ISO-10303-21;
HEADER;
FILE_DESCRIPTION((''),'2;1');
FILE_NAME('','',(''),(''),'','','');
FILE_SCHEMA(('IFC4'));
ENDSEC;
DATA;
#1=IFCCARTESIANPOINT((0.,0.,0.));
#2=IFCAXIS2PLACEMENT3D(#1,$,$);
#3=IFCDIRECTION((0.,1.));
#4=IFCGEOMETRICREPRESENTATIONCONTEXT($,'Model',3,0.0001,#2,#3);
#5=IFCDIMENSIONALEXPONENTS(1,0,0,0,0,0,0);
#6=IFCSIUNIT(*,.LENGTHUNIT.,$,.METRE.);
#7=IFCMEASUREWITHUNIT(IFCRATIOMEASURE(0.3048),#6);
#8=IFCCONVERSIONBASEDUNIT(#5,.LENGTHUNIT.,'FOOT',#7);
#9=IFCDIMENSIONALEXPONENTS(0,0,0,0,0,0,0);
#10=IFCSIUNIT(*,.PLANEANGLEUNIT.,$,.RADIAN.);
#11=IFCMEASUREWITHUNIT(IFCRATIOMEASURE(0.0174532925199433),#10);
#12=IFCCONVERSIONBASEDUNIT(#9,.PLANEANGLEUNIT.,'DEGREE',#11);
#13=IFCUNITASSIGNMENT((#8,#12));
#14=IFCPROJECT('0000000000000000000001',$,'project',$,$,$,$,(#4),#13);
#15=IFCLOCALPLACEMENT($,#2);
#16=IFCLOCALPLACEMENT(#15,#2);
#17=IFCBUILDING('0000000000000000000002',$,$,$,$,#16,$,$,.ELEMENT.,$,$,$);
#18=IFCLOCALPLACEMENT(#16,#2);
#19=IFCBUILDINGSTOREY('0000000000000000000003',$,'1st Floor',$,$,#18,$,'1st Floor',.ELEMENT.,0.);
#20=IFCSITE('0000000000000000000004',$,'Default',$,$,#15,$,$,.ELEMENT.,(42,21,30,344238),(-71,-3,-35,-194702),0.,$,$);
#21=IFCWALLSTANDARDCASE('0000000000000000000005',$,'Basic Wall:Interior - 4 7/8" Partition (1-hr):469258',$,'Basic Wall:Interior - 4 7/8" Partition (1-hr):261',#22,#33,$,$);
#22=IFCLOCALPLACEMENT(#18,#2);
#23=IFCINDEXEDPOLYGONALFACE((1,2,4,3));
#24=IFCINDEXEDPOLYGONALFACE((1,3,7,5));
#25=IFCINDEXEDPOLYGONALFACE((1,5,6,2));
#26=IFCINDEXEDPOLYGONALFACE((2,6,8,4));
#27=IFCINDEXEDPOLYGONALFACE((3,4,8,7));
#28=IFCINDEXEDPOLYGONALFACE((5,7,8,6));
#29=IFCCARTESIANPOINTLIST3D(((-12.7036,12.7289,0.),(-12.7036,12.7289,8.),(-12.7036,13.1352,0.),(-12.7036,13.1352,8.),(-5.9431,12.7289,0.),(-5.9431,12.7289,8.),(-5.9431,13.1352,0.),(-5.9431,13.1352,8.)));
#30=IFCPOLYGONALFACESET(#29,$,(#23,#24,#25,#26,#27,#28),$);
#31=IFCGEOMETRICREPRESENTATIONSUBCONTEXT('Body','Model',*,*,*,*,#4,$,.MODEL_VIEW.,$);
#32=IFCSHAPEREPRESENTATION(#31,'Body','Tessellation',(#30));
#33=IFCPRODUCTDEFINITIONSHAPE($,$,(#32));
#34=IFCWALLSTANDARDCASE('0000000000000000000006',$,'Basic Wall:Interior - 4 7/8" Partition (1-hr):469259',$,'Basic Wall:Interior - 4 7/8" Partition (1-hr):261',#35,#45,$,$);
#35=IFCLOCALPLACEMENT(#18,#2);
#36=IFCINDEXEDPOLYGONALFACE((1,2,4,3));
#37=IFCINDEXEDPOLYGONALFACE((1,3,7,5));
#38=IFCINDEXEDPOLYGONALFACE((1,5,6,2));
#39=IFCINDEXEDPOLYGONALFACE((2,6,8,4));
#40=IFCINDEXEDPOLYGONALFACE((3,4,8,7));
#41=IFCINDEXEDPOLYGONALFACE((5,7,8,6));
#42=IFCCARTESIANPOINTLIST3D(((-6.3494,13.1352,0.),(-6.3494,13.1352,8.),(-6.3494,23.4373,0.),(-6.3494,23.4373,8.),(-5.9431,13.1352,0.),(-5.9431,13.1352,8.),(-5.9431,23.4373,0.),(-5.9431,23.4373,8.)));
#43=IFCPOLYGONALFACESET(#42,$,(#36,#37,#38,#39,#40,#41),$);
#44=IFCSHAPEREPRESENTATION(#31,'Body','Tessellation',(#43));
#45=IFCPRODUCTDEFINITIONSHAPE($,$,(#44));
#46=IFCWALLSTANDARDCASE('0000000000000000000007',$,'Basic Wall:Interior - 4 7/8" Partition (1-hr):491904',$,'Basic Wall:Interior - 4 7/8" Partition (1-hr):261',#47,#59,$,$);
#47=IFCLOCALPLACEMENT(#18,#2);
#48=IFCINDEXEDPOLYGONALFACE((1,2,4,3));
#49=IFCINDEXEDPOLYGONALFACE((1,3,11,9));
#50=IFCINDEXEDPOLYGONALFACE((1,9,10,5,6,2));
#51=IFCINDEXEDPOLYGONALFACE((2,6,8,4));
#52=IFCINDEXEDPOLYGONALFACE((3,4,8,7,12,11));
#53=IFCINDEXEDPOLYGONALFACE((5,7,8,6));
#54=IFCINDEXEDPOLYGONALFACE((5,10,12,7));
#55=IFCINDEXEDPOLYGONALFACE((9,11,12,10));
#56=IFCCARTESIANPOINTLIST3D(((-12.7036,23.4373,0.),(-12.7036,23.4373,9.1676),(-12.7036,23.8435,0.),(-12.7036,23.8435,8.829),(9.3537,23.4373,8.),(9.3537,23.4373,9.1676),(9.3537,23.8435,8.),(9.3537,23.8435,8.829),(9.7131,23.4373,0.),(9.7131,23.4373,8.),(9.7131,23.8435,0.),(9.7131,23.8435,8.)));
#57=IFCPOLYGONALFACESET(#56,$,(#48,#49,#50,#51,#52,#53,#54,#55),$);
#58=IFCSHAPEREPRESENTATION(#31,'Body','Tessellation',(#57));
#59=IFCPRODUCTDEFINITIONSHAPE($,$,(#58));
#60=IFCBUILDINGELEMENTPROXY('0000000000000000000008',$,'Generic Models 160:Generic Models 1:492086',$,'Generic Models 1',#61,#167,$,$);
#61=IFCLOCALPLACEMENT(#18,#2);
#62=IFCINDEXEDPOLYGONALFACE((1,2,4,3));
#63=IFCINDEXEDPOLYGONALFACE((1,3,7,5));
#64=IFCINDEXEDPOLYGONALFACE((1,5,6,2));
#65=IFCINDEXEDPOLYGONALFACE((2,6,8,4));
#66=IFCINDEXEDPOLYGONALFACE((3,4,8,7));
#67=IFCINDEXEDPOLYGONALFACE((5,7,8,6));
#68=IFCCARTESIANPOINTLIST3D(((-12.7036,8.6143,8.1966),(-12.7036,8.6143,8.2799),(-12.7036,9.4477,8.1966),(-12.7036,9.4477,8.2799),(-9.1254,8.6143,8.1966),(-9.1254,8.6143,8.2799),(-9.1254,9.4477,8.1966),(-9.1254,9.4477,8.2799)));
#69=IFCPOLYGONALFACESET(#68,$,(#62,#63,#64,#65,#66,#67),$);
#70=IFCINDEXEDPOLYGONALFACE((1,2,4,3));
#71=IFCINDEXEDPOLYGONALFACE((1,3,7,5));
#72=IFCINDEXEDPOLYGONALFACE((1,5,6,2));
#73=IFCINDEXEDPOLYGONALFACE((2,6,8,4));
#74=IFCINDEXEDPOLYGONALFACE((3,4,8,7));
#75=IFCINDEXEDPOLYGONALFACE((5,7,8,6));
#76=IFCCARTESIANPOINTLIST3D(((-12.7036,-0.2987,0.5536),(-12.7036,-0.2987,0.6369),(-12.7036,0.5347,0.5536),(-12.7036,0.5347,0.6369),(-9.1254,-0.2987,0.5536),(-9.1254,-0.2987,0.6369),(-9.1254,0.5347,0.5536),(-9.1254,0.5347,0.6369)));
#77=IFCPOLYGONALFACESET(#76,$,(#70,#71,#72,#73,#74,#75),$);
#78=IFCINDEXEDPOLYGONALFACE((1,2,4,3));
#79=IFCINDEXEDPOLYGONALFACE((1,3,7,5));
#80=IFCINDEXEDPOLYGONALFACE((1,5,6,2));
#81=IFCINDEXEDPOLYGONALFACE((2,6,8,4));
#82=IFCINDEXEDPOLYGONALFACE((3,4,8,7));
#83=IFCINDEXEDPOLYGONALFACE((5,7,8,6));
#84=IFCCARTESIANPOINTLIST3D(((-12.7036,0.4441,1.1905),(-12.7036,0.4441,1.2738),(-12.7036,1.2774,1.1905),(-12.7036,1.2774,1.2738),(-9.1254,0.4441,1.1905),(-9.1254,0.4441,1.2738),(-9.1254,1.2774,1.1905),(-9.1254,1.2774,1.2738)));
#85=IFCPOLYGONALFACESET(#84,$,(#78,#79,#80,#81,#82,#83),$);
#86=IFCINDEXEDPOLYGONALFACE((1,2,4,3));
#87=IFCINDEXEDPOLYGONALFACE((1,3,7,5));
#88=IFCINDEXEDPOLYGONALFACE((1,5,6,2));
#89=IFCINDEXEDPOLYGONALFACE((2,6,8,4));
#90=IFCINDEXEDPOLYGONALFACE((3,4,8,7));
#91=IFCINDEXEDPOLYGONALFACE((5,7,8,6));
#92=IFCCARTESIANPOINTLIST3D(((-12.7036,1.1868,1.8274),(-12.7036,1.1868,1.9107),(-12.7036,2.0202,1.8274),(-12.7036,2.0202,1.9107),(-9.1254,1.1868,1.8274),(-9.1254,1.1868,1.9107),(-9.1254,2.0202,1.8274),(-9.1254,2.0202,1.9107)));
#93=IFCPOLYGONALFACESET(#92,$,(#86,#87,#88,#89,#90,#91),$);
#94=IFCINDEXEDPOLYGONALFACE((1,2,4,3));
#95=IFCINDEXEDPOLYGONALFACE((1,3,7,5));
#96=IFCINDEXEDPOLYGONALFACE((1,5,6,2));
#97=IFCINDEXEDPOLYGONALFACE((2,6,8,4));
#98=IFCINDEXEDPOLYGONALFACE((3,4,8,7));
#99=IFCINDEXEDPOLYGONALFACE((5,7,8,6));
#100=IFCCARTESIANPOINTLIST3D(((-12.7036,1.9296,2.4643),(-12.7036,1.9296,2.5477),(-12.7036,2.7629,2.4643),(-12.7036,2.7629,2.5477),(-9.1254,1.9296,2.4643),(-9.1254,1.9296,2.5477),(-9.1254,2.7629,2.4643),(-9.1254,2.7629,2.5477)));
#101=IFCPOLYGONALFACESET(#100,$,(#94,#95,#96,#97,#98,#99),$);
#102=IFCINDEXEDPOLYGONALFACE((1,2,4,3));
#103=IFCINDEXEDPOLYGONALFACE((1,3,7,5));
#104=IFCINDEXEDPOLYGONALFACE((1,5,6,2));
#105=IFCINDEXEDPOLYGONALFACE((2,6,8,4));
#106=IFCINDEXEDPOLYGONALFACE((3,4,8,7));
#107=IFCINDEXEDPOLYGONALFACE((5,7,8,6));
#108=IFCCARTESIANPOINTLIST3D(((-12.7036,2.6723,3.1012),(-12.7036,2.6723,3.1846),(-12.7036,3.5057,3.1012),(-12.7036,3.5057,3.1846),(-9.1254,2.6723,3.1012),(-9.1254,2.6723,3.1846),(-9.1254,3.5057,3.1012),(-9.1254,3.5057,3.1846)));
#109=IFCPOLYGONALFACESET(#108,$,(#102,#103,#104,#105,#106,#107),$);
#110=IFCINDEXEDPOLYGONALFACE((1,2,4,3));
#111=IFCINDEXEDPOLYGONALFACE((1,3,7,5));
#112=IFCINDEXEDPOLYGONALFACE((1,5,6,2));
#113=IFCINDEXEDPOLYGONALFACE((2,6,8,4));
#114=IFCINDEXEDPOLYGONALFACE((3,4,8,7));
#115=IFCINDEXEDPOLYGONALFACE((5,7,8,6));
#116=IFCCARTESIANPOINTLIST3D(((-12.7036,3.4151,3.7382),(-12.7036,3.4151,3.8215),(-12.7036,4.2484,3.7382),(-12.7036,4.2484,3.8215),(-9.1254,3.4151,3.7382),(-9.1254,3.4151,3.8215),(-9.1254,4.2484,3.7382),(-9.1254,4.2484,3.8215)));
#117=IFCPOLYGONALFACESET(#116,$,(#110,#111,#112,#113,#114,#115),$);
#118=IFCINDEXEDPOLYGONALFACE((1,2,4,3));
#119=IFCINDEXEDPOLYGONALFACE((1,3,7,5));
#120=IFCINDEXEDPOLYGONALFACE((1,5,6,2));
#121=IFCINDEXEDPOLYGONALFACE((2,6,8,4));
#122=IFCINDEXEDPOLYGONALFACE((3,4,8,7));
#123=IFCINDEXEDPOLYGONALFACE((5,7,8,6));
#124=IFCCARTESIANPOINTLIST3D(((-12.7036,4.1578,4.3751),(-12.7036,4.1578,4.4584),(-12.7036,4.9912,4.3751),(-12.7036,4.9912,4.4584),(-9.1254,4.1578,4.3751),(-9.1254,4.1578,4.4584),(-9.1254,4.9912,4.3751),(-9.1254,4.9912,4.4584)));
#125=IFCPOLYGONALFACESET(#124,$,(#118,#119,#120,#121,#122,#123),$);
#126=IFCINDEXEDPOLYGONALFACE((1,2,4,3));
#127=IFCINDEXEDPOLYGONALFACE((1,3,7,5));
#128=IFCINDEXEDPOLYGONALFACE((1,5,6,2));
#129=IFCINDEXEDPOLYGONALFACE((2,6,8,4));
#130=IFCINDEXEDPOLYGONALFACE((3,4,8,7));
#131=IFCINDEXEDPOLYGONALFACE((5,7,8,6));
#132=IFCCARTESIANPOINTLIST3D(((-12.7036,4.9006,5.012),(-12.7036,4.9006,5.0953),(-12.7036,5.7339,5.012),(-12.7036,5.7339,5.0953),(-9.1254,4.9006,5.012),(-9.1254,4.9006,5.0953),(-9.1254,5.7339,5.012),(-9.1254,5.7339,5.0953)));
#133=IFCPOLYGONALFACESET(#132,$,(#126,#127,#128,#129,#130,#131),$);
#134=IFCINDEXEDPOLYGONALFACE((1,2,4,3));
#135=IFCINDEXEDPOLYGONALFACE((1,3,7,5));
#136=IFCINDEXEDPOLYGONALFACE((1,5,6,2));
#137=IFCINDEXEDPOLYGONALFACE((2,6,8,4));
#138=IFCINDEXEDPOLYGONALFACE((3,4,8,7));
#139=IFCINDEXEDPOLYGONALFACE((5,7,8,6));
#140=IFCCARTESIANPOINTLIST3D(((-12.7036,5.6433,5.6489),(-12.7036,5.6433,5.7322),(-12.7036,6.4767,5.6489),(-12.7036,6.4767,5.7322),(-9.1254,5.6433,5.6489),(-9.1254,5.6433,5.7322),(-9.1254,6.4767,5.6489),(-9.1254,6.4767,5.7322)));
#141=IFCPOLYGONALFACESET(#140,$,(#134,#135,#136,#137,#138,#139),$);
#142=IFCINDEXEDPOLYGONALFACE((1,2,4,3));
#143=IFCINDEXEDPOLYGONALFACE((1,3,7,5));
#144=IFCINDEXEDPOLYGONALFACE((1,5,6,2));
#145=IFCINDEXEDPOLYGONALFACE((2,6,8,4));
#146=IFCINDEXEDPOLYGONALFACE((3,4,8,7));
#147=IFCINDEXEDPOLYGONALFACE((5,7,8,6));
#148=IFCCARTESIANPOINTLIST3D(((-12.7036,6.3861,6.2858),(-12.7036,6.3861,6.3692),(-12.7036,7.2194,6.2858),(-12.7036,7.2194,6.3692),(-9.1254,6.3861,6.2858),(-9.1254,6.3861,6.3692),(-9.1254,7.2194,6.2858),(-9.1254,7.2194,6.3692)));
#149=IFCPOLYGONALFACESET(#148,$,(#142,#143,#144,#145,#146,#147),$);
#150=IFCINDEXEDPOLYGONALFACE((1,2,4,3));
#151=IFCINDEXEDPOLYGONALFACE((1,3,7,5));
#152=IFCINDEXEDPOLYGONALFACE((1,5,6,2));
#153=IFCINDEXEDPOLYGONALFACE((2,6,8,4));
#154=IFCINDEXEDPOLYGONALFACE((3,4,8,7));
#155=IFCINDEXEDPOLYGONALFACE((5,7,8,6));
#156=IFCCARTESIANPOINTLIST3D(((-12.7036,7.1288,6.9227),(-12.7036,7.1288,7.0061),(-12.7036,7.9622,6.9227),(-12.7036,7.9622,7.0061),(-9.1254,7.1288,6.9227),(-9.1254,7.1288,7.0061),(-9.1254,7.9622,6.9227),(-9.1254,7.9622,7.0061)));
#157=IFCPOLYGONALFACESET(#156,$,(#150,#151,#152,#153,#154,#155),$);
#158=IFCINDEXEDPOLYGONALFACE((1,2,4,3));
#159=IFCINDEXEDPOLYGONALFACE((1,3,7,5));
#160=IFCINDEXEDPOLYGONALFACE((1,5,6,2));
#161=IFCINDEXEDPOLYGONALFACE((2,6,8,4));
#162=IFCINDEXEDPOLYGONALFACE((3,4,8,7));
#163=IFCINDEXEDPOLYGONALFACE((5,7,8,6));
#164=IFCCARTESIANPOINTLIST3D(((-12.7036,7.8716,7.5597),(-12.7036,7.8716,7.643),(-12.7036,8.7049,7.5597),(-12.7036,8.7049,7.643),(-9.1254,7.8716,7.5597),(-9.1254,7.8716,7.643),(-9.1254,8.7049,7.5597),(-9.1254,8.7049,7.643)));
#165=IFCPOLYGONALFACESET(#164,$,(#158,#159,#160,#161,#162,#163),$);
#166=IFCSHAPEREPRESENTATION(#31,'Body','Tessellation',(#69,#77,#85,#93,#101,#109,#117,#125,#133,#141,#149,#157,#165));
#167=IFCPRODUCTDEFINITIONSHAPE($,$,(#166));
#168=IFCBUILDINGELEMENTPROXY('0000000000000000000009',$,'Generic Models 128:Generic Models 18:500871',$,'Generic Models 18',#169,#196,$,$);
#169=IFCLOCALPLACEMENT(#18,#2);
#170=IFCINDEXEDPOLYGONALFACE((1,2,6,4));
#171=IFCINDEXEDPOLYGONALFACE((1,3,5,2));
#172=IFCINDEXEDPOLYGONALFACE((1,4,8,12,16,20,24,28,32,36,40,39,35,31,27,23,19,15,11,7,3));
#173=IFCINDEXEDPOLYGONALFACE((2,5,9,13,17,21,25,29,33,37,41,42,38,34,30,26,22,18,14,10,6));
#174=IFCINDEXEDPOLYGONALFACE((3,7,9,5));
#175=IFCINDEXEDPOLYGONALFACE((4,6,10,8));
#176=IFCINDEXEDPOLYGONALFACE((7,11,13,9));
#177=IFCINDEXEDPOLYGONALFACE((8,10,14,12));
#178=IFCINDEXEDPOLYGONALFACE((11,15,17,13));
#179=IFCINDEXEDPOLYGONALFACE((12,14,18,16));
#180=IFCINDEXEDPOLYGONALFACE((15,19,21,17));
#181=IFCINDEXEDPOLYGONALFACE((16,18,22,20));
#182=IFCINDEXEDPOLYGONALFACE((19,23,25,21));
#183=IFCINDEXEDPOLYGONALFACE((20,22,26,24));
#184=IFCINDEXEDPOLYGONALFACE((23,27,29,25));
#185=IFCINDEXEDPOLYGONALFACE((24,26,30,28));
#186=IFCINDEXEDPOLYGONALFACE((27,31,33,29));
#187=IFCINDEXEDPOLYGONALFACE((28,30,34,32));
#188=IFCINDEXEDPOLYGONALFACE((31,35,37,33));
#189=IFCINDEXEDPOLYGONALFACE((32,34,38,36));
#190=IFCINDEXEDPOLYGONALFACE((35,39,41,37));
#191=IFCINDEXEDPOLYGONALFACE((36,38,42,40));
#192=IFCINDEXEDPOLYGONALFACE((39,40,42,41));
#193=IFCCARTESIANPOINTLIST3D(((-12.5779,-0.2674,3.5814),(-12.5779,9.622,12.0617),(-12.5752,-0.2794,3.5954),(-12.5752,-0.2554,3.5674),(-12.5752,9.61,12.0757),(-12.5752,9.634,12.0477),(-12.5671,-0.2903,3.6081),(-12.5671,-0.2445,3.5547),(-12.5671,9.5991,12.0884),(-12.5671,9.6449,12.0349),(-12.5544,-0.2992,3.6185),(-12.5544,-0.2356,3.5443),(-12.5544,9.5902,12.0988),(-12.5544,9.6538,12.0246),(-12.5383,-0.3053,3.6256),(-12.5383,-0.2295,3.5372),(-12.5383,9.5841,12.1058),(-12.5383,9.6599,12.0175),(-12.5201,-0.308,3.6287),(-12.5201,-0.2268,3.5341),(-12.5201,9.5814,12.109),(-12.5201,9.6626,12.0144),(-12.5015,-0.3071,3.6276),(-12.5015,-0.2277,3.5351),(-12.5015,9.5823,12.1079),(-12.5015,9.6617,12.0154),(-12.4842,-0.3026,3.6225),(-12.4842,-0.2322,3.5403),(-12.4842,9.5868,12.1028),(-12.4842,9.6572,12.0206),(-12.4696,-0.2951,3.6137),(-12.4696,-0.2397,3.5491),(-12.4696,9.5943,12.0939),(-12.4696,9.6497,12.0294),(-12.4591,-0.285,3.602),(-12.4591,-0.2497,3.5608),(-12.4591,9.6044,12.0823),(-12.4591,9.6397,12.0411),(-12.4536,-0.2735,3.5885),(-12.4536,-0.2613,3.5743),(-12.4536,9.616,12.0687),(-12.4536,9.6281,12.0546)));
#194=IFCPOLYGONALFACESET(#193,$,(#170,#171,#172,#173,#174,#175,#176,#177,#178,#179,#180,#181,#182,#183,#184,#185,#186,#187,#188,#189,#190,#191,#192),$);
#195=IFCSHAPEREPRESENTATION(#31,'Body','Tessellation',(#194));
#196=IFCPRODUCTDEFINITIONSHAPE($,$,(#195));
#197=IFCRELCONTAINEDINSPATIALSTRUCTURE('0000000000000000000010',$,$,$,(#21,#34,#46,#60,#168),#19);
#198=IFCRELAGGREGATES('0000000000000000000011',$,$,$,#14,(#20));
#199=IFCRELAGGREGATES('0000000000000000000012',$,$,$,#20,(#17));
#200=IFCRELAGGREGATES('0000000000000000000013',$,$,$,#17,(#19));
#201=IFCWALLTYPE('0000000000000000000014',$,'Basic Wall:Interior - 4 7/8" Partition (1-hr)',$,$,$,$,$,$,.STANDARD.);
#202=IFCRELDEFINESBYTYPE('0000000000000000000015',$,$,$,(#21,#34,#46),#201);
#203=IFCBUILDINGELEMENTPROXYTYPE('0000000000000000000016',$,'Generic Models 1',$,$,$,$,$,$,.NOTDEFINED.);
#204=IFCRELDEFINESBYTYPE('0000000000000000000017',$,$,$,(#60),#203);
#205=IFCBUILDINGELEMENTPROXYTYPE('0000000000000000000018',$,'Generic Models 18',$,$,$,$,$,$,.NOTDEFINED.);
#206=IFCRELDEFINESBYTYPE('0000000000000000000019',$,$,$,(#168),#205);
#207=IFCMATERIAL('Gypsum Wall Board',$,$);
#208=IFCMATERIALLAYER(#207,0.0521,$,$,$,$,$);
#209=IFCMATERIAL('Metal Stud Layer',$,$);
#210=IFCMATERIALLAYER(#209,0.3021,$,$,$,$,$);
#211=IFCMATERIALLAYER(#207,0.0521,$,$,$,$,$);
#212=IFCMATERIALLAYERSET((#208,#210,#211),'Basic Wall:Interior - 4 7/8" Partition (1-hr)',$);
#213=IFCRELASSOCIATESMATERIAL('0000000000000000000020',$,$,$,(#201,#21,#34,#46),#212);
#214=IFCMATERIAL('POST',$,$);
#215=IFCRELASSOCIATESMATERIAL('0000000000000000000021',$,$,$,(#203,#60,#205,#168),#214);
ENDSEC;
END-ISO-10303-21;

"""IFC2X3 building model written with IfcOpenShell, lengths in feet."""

from ifc_helpers import new_model, entity, si_unit, converted_unit, direction, frame, frame_2d, origin, place, context, subcontext, project, spatial, polyline, rectangle, circle, extrude, clip, bounded_halfspace, source, transform, mapped, material, layer, layer_set, layer_usage, type_object, type_shapes, element, save


model = new_model("IFC2X3")

# Units and contexts
model_context = context("Model", 3, precision=0.0001, world=origin(), true_north=direction((0.0, 1.0)))
body_context = subcontext(model_context, "Body", "Model", "MODEL_VIEW")
ifc_project = project(units=[converted_unit("LENGTHUNIT", "FOOT", entity("IfcRatioMeasure", 0.3048), si_unit("LENGTHUNIT", "METRE"), dimensions=[1, 0, 0, 0, 0, 0, 0]), converted_unit("PLANEANGLEUNIT", "DEGREE", entity("IfcRatioMeasure", 0.0174532925199433), si_unit("PLANEANGLEUNIT", "RADIAN"), dimensions=[0, 0, 0, 0, 0, 0, 0])], contexts=[model_context])

# Site, building, storey
site_placement = place(None, origin())
site = spatial("IfcSite", under=ifc_project, at=site_placement, Name="Default", CompositionType="ELEMENT", RefLatitude=(42, 21, 30, 344238), RefLongitude=(-71, -3, -35, -194702), RefElevation=0.0)
building_placement = place(site_placement, origin())
building = spatial("IfcBuilding", under=site, at=building_placement, CompositionType="ELEMENT")
storey_placement = place(building_placement, origin())
storey = spatial("IfcBuildingStorey", under=building, at=storey_placement, Name="1st Floor", LongName="1st Floor", CompositionType="ELEMENT", Elevation=0.0)

# Walls
ifc_material_1 = material(Name="Gypsum Wall Board")
ifc_layer_1 = layer(ifc_material_1, 0.0521)
ifc_material_2 = material(Name="Metal Stud Layer")
ifc_layer_2 = layer(ifc_material_2, 0.3021)
ifc_layer_3 = layer(ifc_material_1, 0.0521)
ifc_layer_set = layer_set([ifc_layer_1, ifc_layer_2, ifc_layer_3], Name="Basic Wall:Interior - 4 7/8\" Partition (1-hr)")
ifc_layer_usage_1 = layer_usage(ifc_layer_set, "AXIS2", "NEGATIVE", 0.2031)
wall_type = type_object("IfcWallType", Name="Basic Wall:Interior - 4 7/8\" Partition (1-hr)", PredefinedType="STANDARD", material=ifc_layer_set)
wall_1_placement = place(storey_placement, frame((-12.7036, 12.9321, 0.0)))
element("IfcWallStandardCase", 1, at=wall_1_placement, inside=storey, type_object=wall_type, material=ifc_layer_usage_1, Name="Basic Wall:Interior - 4 7/8\" Partition (1-hr):469258", ObjectType="Basic Wall:Interior - 4 7/8\" Partition (1-hr):261", context=body_context, shape_type="SweptSolid", body=[
    extrude(rectangle(XDim=6.7604, YDim=0.4062, at=frame_2d((3.3802, 0.0), x_axis=(-1.0, 0.0))), origin(), (0.0, 0.0, 1.0), 8.0),
])
ifc_layer_usage_2 = layer_usage(ifc_layer_set, "AXIS2", "NEGATIVE", 0.2031)
wall_2_placement = place(storey_placement, frame((-6.1463, 13.1352, 0.0), z_axis=(0.0, 0.0, 1.0), x_axis=(0.0, 1.0, 0.0)))
element("IfcWallStandardCase", 2, at=wall_2_placement, inside=storey, type_object=wall_type, material=ifc_layer_usage_2, Name="Basic Wall:Interior - 4 7/8\" Partition (1-hr):469259", ObjectType="Basic Wall:Interior - 4 7/8\" Partition (1-hr):261", context=body_context, shape_type="SweptSolid", body=[
    extrude(rectangle(XDim=10.3021, YDim=0.4062, at=frame_2d((5.151, 0.0), x_axis=(-1.0, 0.0))), origin(), (0.0, 0.0, 1.0), 8.0),
])
ifc_layer_usage_3 = layer_usage(ifc_layer_set, "AXIS2", "NEGATIVE", 0.2031)
wall_3_placement = place(storey_placement, frame((-12.7036, 23.6404, 0.0)))
element("IfcWallStandardCase", 3, at=wall_3_placement, inside=storey, type_object=wall_type, material=ifc_layer_usage_3, Name="Basic Wall:Interior - 4 7/8\" Partition (1-hr):491904", ObjectType="Basic Wall:Interior - 4 7/8\" Partition (1-hr):261", context=body_context, shape_type="Clipping", body=[
    clip(clip(extrude(rectangle(XDim=22.4167, YDim=0.4062, at=frame_2d((11.2083, 0.0), x_axis=(-1.0, 0.0))), origin(), (0.0, 0.0, 1.0), 9.1676), bounded_halfspace(frame((0.0, -0.2031, 9.1676), z_axis=(0.0, 0.640184, 0.768221), x_axis=(-1.0, 0.0, 0.0)), False, frame((0.0, -0.2031, 9.1676)), polyline([(0.0, 0.0), (22.0573, 0.0), (22.0573, 0.4062), (0.0, 0.4062), (0.0, 0.0)]))), bounded_halfspace(frame((22.0573, -0.2031, 8.0), z_axis=(0.0, 0.0, 1.0), x_axis=(0.0, 1.0, 0.0)), False, frame((22.0573, -0.2031, 8.0)), polyline([(0.0, 0.0), (0.3594, 0.0), (0.3594, 0.4062), (0.0, 0.4062), (0.0, 0.0)]))),
])

# Building element proxies
ifc_material_3 = material(Name="POST")
building_element_proxy_type_1 = type_object("IfcBuildingElementProxyType", Name="Generic Models 1", PredefinedType="NOTDEFINED", material=ifc_material_3)
shared_shape_1 = source(origin(), body_context, "Body", "SweptSolid", [
    extrude(rectangle(XDim=3.5782, YDim=0.8333, at=frame_2d((0.0, 0.0), x_axis=(1.0, 0.0))), frame((-10.9145, 9.031, 8.1966), z_axis=(0.0, 0.0, 1.0), x_axis=(-1.0, 0.0, 0.0)), (0.0, 0.0, 1.0), 0.0833),
    extrude(rectangle(XDim=3.5782, YDim=0.8333, at=frame_2d((0.0, 0.0), x_axis=(1.0, 0.0))), frame((-10.9145, 0.118, 0.5536), z_axis=(0.0, 0.0, 1.0), x_axis=(-1.0, 0.0, 0.0)), (0.0, 0.0, 1.0), 0.0833),
    extrude(rectangle(XDim=3.5782, YDim=0.8333, at=frame_2d((0.0, 0.0), x_axis=(1.0, 0.0))), frame((-10.9145, 0.8608, 1.1905), z_axis=(0.0, 0.0, 1.0), x_axis=(-1.0, 0.0, 0.0)), (0.0, 0.0, 1.0), 0.0833),
    extrude(rectangle(XDim=3.5782, YDim=0.8333, at=frame_2d((0.0, 0.0), x_axis=(1.0, 0.0))), frame((-10.9145, 1.6035, 1.8274), z_axis=(0.0, 0.0, 1.0), x_axis=(-1.0, 0.0, 0.0)), (0.0, 0.0, 1.0), 0.0833),
    extrude(rectangle(XDim=3.5782, YDim=0.8333, at=frame_2d((0.0, 0.0), x_axis=(1.0, 0.0))), frame((-10.9145, 2.3463, 2.4643), z_axis=(0.0, 0.0, 1.0), x_axis=(-1.0, 0.0, 0.0)), (0.0, 0.0, 1.0), 0.0833),
    extrude(rectangle(XDim=3.5782, YDim=0.8333, at=frame_2d((0.0, 0.0), x_axis=(1.0, 0.0))), frame((-10.9145, 3.089, 3.1012), z_axis=(0.0, 0.0, 1.0), x_axis=(-1.0, 0.0, 0.0)), (0.0, 0.0, 1.0), 0.0833),
    extrude(rectangle(XDim=3.5782, YDim=0.8333, at=frame_2d((0.0, 0.0), x_axis=(1.0, 0.0))), frame((-10.9145, 3.8318, 3.7382), z_axis=(0.0, 0.0, 1.0), x_axis=(-1.0, 0.0, 0.0)), (0.0, 0.0, 1.0), 0.0833),
    extrude(rectangle(XDim=3.5782, YDim=0.8333, at=frame_2d((0.0, 0.0), x_axis=(1.0, 0.0))), frame((-10.9145, 4.5745, 4.3751), z_axis=(0.0, 0.0, 1.0), x_axis=(-1.0, 0.0, 0.0)), (0.0, 0.0, 1.0), 0.0833),
    extrude(rectangle(XDim=3.5782, YDim=0.8333, at=frame_2d((0.0, 0.0), x_axis=(1.0, 0.0))), frame((-10.9145, 5.3173, 5.012), z_axis=(0.0, 0.0, 1.0), x_axis=(-1.0, 0.0, 0.0)), (0.0, 0.0, 1.0), 0.0833),
    extrude(rectangle(XDim=3.5782, YDim=0.8333, at=frame_2d((0.0, 0.0), x_axis=(1.0, 0.0))), frame((-10.9145, 6.06, 5.6489), z_axis=(0.0, 0.0, 1.0), x_axis=(-1.0, 0.0, 0.0)), (0.0, 0.0, 1.0), 0.0833),
    extrude(rectangle(XDim=3.5782, YDim=0.8333, at=frame_2d((0.0, 0.0), x_axis=(1.0, 0.0))), frame((-10.9145, 6.8028, 6.2858), z_axis=(0.0, 0.0, 1.0), x_axis=(-1.0, 0.0, 0.0)), (0.0, 0.0, 1.0), 0.0833),
    extrude(rectangle(XDim=3.5782, YDim=0.8333, at=frame_2d((0.0, 0.0), x_axis=(1.0, 0.0))), frame((-10.9145, 7.5455, 6.9227), z_axis=(0.0, 0.0, 1.0), x_axis=(-1.0, 0.0, 0.0)), (0.0, 0.0, 1.0), 0.0833),
    extrude(rectangle(XDim=3.5782, YDim=0.8333, at=frame_2d((0.0, 0.0), x_axis=(1.0, 0.0))), frame((-10.9145, 8.2883, 7.5597), z_axis=(0.0, 0.0, 1.0), x_axis=(-1.0, 0.0, 0.0)), (0.0, 0.0, 1.0), 0.0833),
])
type_shapes(building_element_proxy_type_1, [shared_shape_1])
proxy_1_placement = place(storey_placement, origin())
element("IfcBuildingElementProxy", 4, at=proxy_1_placement, inside=storey, type_object=building_element_proxy_type_1, material=ifc_material_3, Name="Generic Models 160:Generic Models 1:492086", ObjectType="Generic Models 1", context=body_context, shape_type="MappedRepresentation", body=[
    mapped(shared_shape_1, transform((0.0, 0.0, 0.0), scale=1.0)),
])
building_element_proxy_type_2 = type_object("IfcBuildingElementProxyType", Name="Generic Models 18", PredefinedType="NOTDEFINED", material=ifc_material_3)
shared_shape_2 = source(origin(), body_context, "Body", "SweptSolid", [
    extrude(circle(Radius=0.0625, at=frame_2d((0.0, 0.0), x_axis=(1.0, 0.0))), frame((-12.5154, -0.2674, 3.5814), z_axis=(0.0, 0.759118, 0.650953), x_axis=(-1.0, 0.0, 0.0)), (0.0, 0.0, 1.0), 13.0275),
])
type_shapes(building_element_proxy_type_2, [shared_shape_2])
proxy_2_placement = place(storey_placement, origin())
element("IfcBuildingElementProxy", 5, at=proxy_2_placement, inside=storey, type_object=building_element_proxy_type_2, material=ifc_material_3, Name="Generic Models 128:Generic Models 18:500871", ObjectType="Generic Models 18", context=body_context, shape_type="MappedRepresentation", body=[
    mapped(shared_shape_2, transform((0.0, 0.0, 0.0), scale=1.0)),
])

save(model, "model.ifc")
